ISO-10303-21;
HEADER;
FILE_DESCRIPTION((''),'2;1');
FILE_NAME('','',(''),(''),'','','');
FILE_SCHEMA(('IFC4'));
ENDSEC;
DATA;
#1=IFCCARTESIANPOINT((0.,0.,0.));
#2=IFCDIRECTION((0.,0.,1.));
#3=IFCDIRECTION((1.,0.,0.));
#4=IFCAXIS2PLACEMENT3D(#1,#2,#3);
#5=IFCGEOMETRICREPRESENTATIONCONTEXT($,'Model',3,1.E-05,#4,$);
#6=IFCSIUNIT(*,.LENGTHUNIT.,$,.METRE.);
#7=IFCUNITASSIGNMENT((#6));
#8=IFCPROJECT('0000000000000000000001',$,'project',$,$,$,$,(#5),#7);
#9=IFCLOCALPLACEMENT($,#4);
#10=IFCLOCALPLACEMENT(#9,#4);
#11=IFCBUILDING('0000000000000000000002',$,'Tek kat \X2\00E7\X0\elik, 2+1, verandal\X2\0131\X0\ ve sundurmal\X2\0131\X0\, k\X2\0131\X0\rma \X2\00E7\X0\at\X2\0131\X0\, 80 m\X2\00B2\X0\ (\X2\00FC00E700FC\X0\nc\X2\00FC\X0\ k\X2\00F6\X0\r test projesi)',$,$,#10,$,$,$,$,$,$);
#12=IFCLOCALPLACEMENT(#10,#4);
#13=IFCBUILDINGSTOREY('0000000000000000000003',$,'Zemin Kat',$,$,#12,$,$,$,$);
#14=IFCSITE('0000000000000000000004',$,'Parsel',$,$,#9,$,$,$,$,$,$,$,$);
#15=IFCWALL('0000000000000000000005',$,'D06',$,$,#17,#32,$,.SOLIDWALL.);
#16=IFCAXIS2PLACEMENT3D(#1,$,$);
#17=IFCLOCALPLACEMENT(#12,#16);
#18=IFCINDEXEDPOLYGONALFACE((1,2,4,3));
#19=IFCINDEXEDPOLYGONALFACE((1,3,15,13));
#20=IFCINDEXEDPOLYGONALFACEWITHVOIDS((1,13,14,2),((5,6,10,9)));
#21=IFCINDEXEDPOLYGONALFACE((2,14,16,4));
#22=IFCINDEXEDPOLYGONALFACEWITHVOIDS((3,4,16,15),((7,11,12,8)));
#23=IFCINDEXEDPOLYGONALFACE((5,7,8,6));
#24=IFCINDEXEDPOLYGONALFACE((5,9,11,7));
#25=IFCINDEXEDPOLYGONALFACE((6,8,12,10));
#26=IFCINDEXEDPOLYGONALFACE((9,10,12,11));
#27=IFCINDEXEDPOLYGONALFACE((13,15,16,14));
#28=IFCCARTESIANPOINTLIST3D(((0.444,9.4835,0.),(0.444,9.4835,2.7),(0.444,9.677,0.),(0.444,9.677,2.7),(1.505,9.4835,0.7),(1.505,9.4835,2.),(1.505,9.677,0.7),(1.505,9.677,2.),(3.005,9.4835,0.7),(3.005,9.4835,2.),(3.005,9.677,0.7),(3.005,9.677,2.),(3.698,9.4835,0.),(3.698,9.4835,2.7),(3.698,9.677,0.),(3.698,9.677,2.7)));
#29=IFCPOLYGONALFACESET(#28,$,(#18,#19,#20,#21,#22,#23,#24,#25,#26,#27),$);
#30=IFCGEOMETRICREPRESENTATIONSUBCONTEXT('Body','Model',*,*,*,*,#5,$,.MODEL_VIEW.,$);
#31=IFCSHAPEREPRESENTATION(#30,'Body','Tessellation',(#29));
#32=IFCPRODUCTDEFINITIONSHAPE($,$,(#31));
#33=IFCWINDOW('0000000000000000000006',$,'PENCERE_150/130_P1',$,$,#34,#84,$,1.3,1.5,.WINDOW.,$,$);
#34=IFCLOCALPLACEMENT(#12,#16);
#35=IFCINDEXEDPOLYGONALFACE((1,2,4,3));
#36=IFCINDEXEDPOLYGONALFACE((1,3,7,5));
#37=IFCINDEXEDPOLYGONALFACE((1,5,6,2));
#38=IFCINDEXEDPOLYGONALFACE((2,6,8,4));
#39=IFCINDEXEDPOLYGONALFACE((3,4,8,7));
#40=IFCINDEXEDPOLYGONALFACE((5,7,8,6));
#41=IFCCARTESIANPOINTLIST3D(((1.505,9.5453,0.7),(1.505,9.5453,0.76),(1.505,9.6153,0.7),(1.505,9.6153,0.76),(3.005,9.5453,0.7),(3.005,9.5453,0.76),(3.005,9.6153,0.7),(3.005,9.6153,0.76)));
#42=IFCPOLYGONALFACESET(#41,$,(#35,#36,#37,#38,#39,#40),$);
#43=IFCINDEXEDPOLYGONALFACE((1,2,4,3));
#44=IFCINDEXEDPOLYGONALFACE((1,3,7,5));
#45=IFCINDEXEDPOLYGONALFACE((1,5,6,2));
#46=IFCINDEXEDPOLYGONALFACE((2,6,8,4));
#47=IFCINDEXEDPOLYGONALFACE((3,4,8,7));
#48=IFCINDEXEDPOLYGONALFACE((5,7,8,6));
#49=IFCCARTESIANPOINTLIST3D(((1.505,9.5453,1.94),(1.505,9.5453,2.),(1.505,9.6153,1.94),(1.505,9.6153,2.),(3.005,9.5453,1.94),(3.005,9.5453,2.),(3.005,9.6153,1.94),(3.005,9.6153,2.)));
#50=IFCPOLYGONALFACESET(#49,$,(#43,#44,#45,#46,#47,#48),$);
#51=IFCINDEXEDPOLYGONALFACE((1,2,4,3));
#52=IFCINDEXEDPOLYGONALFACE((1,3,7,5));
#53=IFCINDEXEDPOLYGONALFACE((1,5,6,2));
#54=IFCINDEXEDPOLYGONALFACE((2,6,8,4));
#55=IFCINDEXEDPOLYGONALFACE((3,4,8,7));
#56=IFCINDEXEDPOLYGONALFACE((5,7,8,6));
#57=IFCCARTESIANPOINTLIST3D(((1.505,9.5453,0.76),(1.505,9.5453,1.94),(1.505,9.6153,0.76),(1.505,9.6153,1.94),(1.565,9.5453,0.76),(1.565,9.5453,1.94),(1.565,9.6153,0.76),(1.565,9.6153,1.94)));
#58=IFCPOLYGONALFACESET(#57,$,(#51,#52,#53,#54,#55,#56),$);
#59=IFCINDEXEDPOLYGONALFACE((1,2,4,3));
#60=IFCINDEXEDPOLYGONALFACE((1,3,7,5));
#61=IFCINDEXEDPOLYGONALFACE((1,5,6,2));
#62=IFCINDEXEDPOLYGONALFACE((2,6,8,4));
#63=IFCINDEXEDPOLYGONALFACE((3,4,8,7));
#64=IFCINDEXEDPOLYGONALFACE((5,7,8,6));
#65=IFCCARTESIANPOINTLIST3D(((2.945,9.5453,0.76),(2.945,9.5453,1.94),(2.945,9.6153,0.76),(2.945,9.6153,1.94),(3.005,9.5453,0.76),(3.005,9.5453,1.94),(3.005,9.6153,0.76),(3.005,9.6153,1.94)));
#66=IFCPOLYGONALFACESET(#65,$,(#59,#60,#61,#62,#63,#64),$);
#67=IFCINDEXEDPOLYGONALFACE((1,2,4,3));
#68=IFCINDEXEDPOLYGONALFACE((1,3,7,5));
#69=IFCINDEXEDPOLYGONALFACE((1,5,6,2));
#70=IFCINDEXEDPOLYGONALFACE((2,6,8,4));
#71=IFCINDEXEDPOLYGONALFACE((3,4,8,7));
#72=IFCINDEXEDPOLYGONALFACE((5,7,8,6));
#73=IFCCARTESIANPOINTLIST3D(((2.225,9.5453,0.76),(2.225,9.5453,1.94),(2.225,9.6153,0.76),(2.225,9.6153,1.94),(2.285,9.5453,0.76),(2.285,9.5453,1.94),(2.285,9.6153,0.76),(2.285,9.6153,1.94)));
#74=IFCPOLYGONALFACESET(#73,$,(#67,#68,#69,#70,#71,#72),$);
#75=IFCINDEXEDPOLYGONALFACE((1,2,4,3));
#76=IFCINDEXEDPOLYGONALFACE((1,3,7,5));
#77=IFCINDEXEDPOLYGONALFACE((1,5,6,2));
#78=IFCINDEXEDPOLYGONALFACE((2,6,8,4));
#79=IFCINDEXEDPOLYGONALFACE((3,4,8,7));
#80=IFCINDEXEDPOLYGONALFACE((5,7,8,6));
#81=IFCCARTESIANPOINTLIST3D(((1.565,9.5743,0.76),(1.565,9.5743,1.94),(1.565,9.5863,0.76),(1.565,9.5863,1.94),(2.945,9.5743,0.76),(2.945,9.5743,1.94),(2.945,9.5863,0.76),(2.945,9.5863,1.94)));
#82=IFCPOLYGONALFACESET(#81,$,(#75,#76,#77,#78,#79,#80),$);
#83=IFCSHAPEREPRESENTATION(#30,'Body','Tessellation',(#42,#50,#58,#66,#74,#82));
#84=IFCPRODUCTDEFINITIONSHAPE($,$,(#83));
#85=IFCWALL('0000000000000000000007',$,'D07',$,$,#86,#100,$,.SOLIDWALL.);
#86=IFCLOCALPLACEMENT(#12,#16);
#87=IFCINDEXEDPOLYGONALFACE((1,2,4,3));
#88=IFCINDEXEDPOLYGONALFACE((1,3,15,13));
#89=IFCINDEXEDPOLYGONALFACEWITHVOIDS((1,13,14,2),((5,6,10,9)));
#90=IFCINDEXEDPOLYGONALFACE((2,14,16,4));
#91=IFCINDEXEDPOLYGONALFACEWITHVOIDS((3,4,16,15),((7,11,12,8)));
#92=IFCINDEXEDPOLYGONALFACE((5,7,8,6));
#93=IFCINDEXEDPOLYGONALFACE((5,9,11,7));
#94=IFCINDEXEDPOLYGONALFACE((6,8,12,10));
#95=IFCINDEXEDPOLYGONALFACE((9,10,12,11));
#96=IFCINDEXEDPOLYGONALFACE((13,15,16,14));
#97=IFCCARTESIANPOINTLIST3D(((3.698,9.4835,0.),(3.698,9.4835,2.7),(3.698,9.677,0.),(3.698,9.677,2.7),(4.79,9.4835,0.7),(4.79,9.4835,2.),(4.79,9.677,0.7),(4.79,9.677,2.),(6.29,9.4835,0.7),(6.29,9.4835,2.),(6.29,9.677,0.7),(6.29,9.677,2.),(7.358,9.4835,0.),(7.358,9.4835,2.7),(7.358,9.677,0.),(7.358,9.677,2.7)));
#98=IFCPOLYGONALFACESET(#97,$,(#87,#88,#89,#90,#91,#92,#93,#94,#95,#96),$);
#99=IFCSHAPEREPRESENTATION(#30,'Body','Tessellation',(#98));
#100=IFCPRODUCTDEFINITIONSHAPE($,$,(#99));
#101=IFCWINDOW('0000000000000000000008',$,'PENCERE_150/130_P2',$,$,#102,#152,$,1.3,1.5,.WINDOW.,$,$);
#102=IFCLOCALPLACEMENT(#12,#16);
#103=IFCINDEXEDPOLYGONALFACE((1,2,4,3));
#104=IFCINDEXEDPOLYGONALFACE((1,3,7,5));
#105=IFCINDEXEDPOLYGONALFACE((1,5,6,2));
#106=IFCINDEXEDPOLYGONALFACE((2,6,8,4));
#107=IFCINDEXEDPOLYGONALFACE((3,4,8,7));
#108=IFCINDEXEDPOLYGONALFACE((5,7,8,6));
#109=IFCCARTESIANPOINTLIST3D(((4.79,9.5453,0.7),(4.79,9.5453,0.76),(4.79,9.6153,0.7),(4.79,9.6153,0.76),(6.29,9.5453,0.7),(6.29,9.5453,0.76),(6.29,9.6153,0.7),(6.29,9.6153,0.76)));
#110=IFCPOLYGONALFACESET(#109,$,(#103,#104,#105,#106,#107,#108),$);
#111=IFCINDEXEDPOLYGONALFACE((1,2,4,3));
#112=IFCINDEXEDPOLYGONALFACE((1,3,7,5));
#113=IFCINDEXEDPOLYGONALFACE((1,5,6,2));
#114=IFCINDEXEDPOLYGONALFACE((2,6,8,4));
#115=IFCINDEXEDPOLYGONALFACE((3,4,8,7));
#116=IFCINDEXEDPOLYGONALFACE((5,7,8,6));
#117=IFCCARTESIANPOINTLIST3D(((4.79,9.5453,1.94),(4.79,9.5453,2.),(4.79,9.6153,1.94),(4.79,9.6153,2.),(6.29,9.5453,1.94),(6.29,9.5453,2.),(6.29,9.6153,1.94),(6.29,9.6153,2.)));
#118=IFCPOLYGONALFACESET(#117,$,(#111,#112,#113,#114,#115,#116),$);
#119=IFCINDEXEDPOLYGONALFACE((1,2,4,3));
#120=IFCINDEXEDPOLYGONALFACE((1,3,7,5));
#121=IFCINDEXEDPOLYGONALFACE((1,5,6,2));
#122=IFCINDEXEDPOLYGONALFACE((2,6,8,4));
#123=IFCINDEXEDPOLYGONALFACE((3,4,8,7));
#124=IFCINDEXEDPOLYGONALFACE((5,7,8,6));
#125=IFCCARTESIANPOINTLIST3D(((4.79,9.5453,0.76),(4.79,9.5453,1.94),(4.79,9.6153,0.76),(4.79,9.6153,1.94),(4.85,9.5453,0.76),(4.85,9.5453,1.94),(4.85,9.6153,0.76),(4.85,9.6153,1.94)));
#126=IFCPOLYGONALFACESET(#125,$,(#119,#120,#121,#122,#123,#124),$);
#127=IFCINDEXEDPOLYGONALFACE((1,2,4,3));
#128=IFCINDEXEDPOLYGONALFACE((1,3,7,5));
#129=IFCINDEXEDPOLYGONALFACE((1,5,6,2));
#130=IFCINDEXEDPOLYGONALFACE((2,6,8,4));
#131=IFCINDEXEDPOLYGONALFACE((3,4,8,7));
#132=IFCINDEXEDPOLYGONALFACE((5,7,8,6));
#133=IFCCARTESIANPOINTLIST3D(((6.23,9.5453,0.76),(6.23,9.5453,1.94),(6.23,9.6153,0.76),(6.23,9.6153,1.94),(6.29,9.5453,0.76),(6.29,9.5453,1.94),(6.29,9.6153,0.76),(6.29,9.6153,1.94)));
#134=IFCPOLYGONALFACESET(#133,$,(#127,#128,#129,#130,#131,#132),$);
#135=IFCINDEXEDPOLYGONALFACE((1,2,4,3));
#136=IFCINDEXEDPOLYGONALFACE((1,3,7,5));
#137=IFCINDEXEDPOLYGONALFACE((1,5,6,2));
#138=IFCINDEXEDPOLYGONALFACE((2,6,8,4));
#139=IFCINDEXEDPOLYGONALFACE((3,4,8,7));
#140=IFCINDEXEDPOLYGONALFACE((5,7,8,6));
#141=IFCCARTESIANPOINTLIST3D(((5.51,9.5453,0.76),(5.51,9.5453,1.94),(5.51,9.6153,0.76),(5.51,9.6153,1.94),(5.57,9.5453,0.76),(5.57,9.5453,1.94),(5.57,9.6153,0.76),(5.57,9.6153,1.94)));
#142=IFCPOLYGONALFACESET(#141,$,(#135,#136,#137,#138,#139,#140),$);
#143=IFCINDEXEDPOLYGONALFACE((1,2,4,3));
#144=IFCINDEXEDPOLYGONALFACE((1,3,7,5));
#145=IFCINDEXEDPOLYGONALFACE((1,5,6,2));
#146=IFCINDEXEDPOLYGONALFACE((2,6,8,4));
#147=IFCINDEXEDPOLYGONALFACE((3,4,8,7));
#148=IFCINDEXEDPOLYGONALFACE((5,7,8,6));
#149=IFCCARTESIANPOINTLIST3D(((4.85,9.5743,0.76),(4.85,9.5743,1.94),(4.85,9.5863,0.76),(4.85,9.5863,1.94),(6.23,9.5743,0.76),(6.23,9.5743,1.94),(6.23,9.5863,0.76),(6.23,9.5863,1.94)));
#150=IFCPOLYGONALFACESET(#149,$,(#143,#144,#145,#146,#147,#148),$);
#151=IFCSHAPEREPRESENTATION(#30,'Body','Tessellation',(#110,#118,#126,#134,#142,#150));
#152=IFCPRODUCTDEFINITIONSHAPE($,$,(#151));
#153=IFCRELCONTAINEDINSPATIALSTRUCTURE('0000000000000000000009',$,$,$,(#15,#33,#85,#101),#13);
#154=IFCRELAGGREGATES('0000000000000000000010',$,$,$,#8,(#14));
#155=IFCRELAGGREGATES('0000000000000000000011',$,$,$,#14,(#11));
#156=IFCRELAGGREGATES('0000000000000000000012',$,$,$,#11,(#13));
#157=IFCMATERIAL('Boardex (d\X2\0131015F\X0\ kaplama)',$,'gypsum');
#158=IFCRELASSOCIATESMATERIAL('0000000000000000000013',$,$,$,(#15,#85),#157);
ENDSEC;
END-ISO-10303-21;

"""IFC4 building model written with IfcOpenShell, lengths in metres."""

from ifc_helpers import new_model, si_unit, frame, origin_with_axes, place, context, subcontext, project, spatial, line, indexed_curve, outline, extrude, material, element, fill, save


model = new_model("IFC4")

# Units and contexts
model_context = context("Model", 3, precision=1e-05, world=origin_with_axes())
body_context = subcontext(model_context, "Body", "Model", "MODEL_VIEW")
ifc_project = project(units=[si_unit("LENGTHUNIT", "METRE")], contexts=[model_context])

# Site, building, storey
site_placement = place(None, origin_with_axes())
site = spatial("IfcSite", under=ifc_project, at=site_placement, Name="Parsel")
building_placement = place(site_placement, origin_with_axes())
building = spatial("IfcBuilding", under=site, at=building_placement, Name="Tek kat çelik, 2+1, verandalı ve sundurmalı, kırma çatı, 80 m² (üçüncü kör test projesi)")
storey_placement = place(building_placement, origin_with_axes())
storey = spatial("IfcBuildingStorey", under=building, at=storey_placement, Name="Zemin Kat")

# Shared definitions
ifc_material_1 = material(Name="Boardex (dış kaplama)", Category="gypsum")

# Walls, openings, windows
wall_1_placement = place(storey_placement, origin_with_axes())
wall_1 = element("IfcWall", 1, at=wall_1_placement, inside=storey, material=ifc_material_1, Name="D06", PredefinedType="SOLIDWALL", context=body_context, shape_type="SweptSolid", body=[
    extrude(outline(indexed_curve([(0.0, 0.0), (3.254, 0.0), (3.254, 0.1935), (0.0, 0.1935)], segments=[line(1, 2, 3, 4, 1)])), frame((0.444, 9.4835, 0.0), z_axis=(0.0, 0.0, 1.0), x_axis=(1.0, 0.0, 0.0)), (0.0, 0.0, 1.0), 2.7),
])
opening_1_placement = place(wall_1_placement, origin_with_axes())
opening_1 = element("IfcOpeningElement", 2, at=opening_1_placement, cuts=wall_1, PredefinedType="OPENING", context=body_context, shape_type="SweptSolid", body=[
    extrude(outline(indexed_curve([(0.0, 0.0), (1.5, 0.0), (1.5, 0.2335), (0.0, 0.2335)], segments=[line(1, 2, 3, 4, 1)])), frame((1.505, 9.4635, 0.7), z_axis=(0.0, 0.0, 1.0), x_axis=(1.0, 0.0, 0.0)), (0.0, 0.0, 1.0), 1.3),
])
window_1_placement = place(storey_placement, origin_with_axes())
window_1 = element("IfcWindow", 3, at=window_1_placement, inside=storey, Name="PENCERE_150/130_P1", OverallHeight=1.3, OverallWidth=1.5, PredefinedType="WINDOW", context=body_context, shape_type="SweptSolid", body=[
    extrude(outline(indexed_curve([(0.0, 0.0), (1.5, 0.0), (1.5, 0.07), (0.0, 0.07)], segments=[line(1, 2, 3, 4, 1)])), frame((1.505, 9.5453, 0.7), z_axis=(0.0, 0.0, 1.0), x_axis=(1.0, 0.0, 0.0)), (0.0, 0.0, 1.0), 0.06),
    extrude(outline(indexed_curve([(0.0, 0.0), (1.5, 0.0), (1.5, 0.07), (0.0, 0.07)], segments=[line(1, 2, 3, 4, 1)])), frame((1.505, 9.5453, 1.94), z_axis=(0.0, 0.0, 1.0), x_axis=(1.0, 0.0, 0.0)), (0.0, 0.0, 1.0), 0.06),
    extrude(outline(indexed_curve([(0.0, 0.0), (0.06, 0.0), (0.06, 0.07), (0.0, 0.07)], segments=[line(1, 2, 3, 4, 1)])), frame((1.505, 9.5453, 0.76), z_axis=(0.0, 0.0, 1.0), x_axis=(1.0, 0.0, 0.0)), (0.0, 0.0, 1.0), 1.18),
    extrude(outline(indexed_curve([(0.0, 0.0), (0.06, 0.0), (0.06, 0.07), (0.0, 0.07)], segments=[line(1, 2, 3, 4, 1)])), frame((2.945, 9.5453, 0.76), z_axis=(0.0, 0.0, 1.0), x_axis=(1.0, 0.0, 0.0)), (0.0, 0.0, 1.0), 1.18),
    extrude(outline(indexed_curve([(0.0, 0.0), (0.06, 0.0), (0.06, 0.07), (0.0, 0.07)], segments=[line(1, 2, 3, 4, 1)])), frame((2.225, 9.5453, 0.76), z_axis=(0.0, 0.0, 1.0), x_axis=(1.0, 0.0, 0.0)), (0.0, 0.0, 1.0), 1.18),
    extrude(outline(indexed_curve([(0.0, 0.0), (1.38, 0.0), (1.38, 0.012), (0.0, 0.012)], segments=[line(1, 2, 3, 4, 1)])), frame((1.565, 9.5743, 0.76), z_axis=(0.0, 0.0, 1.0), x_axis=(1.0, 0.0, 0.0)), (0.0, 0.0, 1.0), 1.18),
])
fill(opening_1, window_1)
wall_2_placement = place(storey_placement, origin_with_axes())
wall_2 = element("IfcWall", 4, at=wall_2_placement, inside=storey, material=ifc_material_1, Name="D07", PredefinedType="SOLIDWALL", context=body_context, shape_type="SweptSolid", body=[
    extrude(outline(indexed_curve([(0.0, 0.0), (3.66, 0.0), (3.66, 0.1935), (0.0, 0.1935)], segments=[line(1, 2, 3, 4, 1)])), frame((3.698, 9.4835, 0.0), z_axis=(0.0, 0.0, 1.0), x_axis=(1.0, 0.0, 0.0)), (0.0, 0.0, 1.0), 2.7),
])
opening_2_placement = place(wall_2_placement, origin_with_axes())
opening_2 = element("IfcOpeningElement", 5, at=opening_2_placement, cuts=wall_2, PredefinedType="OPENING", context=body_context, shape_type="SweptSolid", body=[
    extrude(outline(indexed_curve([(0.0, 0.0), (1.5, 0.0), (1.5, 0.2335), (0.0, 0.2335)], segments=[line(1, 2, 3, 4, 1)])), frame((4.79, 9.4635, 0.7), z_axis=(0.0, 0.0, 1.0), x_axis=(1.0, 0.0, 0.0)), (0.0, 0.0, 1.0), 1.3),
])
window_2_placement = place(storey_placement, origin_with_axes())
window_2 = element("IfcWindow", 6, at=window_2_placement, inside=storey, Name="PENCERE_150/130_P2", OverallHeight=1.3, OverallWidth=1.5, PredefinedType="WINDOW", context=body_context, shape_type="SweptSolid", body=[
    extrude(outline(indexed_curve([(0.0, 0.0), (1.5, 0.0), (1.5, 0.07), (0.0, 0.07)], segments=[line(1, 2, 3, 4, 1)])), frame((4.79, 9.5453, 0.7), z_axis=(0.0, 0.0, 1.0), x_axis=(1.0, 0.0, 0.0)), (0.0, 0.0, 1.0), 0.06),
    extrude(outline(indexed_curve([(0.0, 0.0), (1.5, 0.0), (1.5, 0.07), (0.0, 0.07)], segments=[line(1, 2, 3, 4, 1)])), frame((4.79, 9.5453, 1.94), z_axis=(0.0, 0.0, 1.0), x_axis=(1.0, 0.0, 0.0)), (0.0, 0.0, 1.0), 0.06),
    extrude(outline(indexed_curve([(0.0, 0.0), (0.06, 0.0), (0.06, 0.07), (0.0, 0.07)], segments=[line(1, 2, 3, 4, 1)])), frame((4.79, 9.5453, 0.76), z_axis=(0.0, 0.0, 1.0), x_axis=(1.0, 0.0, 0.0)), (0.0, 0.0, 1.0), 1.18),
    extrude(outline(indexed_curve([(0.0, 0.0), (0.06, 0.0), (0.06, 0.07), (0.0, 0.07)], segments=[line(1, 2, 3, 4, 1)])), frame((6.23, 9.5453, 0.76), z_axis=(0.0, 0.0, 1.0), x_axis=(1.0, 0.0, 0.0)), (0.0, 0.0, 1.0), 1.18),
    extrude(outline(indexed_curve([(0.0, 0.0), (0.06, 0.0), (0.06, 0.07), (0.0, 0.07)], segments=[line(1, 2, 3, 4, 1)])), frame((5.51, 9.5453, 0.76), z_axis=(0.0, 0.0, 1.0), x_axis=(1.0, 0.0, 0.0)), (0.0, 0.0, 1.0), 1.18),
    extrude(outline(indexed_curve([(0.0, 0.0), (1.38, 0.0), (1.38, 0.012), (0.0, 0.012)], segments=[line(1, 2, 3, 4, 1)])), frame((4.85, 9.5743, 0.76), z_axis=(0.0, 0.0, 1.0), x_axis=(1.0, 0.0, 0.0)), (0.0, 0.0, 1.0), 1.18),
])
fill(opening_2, window_2)

save(model, "model.ifc")
